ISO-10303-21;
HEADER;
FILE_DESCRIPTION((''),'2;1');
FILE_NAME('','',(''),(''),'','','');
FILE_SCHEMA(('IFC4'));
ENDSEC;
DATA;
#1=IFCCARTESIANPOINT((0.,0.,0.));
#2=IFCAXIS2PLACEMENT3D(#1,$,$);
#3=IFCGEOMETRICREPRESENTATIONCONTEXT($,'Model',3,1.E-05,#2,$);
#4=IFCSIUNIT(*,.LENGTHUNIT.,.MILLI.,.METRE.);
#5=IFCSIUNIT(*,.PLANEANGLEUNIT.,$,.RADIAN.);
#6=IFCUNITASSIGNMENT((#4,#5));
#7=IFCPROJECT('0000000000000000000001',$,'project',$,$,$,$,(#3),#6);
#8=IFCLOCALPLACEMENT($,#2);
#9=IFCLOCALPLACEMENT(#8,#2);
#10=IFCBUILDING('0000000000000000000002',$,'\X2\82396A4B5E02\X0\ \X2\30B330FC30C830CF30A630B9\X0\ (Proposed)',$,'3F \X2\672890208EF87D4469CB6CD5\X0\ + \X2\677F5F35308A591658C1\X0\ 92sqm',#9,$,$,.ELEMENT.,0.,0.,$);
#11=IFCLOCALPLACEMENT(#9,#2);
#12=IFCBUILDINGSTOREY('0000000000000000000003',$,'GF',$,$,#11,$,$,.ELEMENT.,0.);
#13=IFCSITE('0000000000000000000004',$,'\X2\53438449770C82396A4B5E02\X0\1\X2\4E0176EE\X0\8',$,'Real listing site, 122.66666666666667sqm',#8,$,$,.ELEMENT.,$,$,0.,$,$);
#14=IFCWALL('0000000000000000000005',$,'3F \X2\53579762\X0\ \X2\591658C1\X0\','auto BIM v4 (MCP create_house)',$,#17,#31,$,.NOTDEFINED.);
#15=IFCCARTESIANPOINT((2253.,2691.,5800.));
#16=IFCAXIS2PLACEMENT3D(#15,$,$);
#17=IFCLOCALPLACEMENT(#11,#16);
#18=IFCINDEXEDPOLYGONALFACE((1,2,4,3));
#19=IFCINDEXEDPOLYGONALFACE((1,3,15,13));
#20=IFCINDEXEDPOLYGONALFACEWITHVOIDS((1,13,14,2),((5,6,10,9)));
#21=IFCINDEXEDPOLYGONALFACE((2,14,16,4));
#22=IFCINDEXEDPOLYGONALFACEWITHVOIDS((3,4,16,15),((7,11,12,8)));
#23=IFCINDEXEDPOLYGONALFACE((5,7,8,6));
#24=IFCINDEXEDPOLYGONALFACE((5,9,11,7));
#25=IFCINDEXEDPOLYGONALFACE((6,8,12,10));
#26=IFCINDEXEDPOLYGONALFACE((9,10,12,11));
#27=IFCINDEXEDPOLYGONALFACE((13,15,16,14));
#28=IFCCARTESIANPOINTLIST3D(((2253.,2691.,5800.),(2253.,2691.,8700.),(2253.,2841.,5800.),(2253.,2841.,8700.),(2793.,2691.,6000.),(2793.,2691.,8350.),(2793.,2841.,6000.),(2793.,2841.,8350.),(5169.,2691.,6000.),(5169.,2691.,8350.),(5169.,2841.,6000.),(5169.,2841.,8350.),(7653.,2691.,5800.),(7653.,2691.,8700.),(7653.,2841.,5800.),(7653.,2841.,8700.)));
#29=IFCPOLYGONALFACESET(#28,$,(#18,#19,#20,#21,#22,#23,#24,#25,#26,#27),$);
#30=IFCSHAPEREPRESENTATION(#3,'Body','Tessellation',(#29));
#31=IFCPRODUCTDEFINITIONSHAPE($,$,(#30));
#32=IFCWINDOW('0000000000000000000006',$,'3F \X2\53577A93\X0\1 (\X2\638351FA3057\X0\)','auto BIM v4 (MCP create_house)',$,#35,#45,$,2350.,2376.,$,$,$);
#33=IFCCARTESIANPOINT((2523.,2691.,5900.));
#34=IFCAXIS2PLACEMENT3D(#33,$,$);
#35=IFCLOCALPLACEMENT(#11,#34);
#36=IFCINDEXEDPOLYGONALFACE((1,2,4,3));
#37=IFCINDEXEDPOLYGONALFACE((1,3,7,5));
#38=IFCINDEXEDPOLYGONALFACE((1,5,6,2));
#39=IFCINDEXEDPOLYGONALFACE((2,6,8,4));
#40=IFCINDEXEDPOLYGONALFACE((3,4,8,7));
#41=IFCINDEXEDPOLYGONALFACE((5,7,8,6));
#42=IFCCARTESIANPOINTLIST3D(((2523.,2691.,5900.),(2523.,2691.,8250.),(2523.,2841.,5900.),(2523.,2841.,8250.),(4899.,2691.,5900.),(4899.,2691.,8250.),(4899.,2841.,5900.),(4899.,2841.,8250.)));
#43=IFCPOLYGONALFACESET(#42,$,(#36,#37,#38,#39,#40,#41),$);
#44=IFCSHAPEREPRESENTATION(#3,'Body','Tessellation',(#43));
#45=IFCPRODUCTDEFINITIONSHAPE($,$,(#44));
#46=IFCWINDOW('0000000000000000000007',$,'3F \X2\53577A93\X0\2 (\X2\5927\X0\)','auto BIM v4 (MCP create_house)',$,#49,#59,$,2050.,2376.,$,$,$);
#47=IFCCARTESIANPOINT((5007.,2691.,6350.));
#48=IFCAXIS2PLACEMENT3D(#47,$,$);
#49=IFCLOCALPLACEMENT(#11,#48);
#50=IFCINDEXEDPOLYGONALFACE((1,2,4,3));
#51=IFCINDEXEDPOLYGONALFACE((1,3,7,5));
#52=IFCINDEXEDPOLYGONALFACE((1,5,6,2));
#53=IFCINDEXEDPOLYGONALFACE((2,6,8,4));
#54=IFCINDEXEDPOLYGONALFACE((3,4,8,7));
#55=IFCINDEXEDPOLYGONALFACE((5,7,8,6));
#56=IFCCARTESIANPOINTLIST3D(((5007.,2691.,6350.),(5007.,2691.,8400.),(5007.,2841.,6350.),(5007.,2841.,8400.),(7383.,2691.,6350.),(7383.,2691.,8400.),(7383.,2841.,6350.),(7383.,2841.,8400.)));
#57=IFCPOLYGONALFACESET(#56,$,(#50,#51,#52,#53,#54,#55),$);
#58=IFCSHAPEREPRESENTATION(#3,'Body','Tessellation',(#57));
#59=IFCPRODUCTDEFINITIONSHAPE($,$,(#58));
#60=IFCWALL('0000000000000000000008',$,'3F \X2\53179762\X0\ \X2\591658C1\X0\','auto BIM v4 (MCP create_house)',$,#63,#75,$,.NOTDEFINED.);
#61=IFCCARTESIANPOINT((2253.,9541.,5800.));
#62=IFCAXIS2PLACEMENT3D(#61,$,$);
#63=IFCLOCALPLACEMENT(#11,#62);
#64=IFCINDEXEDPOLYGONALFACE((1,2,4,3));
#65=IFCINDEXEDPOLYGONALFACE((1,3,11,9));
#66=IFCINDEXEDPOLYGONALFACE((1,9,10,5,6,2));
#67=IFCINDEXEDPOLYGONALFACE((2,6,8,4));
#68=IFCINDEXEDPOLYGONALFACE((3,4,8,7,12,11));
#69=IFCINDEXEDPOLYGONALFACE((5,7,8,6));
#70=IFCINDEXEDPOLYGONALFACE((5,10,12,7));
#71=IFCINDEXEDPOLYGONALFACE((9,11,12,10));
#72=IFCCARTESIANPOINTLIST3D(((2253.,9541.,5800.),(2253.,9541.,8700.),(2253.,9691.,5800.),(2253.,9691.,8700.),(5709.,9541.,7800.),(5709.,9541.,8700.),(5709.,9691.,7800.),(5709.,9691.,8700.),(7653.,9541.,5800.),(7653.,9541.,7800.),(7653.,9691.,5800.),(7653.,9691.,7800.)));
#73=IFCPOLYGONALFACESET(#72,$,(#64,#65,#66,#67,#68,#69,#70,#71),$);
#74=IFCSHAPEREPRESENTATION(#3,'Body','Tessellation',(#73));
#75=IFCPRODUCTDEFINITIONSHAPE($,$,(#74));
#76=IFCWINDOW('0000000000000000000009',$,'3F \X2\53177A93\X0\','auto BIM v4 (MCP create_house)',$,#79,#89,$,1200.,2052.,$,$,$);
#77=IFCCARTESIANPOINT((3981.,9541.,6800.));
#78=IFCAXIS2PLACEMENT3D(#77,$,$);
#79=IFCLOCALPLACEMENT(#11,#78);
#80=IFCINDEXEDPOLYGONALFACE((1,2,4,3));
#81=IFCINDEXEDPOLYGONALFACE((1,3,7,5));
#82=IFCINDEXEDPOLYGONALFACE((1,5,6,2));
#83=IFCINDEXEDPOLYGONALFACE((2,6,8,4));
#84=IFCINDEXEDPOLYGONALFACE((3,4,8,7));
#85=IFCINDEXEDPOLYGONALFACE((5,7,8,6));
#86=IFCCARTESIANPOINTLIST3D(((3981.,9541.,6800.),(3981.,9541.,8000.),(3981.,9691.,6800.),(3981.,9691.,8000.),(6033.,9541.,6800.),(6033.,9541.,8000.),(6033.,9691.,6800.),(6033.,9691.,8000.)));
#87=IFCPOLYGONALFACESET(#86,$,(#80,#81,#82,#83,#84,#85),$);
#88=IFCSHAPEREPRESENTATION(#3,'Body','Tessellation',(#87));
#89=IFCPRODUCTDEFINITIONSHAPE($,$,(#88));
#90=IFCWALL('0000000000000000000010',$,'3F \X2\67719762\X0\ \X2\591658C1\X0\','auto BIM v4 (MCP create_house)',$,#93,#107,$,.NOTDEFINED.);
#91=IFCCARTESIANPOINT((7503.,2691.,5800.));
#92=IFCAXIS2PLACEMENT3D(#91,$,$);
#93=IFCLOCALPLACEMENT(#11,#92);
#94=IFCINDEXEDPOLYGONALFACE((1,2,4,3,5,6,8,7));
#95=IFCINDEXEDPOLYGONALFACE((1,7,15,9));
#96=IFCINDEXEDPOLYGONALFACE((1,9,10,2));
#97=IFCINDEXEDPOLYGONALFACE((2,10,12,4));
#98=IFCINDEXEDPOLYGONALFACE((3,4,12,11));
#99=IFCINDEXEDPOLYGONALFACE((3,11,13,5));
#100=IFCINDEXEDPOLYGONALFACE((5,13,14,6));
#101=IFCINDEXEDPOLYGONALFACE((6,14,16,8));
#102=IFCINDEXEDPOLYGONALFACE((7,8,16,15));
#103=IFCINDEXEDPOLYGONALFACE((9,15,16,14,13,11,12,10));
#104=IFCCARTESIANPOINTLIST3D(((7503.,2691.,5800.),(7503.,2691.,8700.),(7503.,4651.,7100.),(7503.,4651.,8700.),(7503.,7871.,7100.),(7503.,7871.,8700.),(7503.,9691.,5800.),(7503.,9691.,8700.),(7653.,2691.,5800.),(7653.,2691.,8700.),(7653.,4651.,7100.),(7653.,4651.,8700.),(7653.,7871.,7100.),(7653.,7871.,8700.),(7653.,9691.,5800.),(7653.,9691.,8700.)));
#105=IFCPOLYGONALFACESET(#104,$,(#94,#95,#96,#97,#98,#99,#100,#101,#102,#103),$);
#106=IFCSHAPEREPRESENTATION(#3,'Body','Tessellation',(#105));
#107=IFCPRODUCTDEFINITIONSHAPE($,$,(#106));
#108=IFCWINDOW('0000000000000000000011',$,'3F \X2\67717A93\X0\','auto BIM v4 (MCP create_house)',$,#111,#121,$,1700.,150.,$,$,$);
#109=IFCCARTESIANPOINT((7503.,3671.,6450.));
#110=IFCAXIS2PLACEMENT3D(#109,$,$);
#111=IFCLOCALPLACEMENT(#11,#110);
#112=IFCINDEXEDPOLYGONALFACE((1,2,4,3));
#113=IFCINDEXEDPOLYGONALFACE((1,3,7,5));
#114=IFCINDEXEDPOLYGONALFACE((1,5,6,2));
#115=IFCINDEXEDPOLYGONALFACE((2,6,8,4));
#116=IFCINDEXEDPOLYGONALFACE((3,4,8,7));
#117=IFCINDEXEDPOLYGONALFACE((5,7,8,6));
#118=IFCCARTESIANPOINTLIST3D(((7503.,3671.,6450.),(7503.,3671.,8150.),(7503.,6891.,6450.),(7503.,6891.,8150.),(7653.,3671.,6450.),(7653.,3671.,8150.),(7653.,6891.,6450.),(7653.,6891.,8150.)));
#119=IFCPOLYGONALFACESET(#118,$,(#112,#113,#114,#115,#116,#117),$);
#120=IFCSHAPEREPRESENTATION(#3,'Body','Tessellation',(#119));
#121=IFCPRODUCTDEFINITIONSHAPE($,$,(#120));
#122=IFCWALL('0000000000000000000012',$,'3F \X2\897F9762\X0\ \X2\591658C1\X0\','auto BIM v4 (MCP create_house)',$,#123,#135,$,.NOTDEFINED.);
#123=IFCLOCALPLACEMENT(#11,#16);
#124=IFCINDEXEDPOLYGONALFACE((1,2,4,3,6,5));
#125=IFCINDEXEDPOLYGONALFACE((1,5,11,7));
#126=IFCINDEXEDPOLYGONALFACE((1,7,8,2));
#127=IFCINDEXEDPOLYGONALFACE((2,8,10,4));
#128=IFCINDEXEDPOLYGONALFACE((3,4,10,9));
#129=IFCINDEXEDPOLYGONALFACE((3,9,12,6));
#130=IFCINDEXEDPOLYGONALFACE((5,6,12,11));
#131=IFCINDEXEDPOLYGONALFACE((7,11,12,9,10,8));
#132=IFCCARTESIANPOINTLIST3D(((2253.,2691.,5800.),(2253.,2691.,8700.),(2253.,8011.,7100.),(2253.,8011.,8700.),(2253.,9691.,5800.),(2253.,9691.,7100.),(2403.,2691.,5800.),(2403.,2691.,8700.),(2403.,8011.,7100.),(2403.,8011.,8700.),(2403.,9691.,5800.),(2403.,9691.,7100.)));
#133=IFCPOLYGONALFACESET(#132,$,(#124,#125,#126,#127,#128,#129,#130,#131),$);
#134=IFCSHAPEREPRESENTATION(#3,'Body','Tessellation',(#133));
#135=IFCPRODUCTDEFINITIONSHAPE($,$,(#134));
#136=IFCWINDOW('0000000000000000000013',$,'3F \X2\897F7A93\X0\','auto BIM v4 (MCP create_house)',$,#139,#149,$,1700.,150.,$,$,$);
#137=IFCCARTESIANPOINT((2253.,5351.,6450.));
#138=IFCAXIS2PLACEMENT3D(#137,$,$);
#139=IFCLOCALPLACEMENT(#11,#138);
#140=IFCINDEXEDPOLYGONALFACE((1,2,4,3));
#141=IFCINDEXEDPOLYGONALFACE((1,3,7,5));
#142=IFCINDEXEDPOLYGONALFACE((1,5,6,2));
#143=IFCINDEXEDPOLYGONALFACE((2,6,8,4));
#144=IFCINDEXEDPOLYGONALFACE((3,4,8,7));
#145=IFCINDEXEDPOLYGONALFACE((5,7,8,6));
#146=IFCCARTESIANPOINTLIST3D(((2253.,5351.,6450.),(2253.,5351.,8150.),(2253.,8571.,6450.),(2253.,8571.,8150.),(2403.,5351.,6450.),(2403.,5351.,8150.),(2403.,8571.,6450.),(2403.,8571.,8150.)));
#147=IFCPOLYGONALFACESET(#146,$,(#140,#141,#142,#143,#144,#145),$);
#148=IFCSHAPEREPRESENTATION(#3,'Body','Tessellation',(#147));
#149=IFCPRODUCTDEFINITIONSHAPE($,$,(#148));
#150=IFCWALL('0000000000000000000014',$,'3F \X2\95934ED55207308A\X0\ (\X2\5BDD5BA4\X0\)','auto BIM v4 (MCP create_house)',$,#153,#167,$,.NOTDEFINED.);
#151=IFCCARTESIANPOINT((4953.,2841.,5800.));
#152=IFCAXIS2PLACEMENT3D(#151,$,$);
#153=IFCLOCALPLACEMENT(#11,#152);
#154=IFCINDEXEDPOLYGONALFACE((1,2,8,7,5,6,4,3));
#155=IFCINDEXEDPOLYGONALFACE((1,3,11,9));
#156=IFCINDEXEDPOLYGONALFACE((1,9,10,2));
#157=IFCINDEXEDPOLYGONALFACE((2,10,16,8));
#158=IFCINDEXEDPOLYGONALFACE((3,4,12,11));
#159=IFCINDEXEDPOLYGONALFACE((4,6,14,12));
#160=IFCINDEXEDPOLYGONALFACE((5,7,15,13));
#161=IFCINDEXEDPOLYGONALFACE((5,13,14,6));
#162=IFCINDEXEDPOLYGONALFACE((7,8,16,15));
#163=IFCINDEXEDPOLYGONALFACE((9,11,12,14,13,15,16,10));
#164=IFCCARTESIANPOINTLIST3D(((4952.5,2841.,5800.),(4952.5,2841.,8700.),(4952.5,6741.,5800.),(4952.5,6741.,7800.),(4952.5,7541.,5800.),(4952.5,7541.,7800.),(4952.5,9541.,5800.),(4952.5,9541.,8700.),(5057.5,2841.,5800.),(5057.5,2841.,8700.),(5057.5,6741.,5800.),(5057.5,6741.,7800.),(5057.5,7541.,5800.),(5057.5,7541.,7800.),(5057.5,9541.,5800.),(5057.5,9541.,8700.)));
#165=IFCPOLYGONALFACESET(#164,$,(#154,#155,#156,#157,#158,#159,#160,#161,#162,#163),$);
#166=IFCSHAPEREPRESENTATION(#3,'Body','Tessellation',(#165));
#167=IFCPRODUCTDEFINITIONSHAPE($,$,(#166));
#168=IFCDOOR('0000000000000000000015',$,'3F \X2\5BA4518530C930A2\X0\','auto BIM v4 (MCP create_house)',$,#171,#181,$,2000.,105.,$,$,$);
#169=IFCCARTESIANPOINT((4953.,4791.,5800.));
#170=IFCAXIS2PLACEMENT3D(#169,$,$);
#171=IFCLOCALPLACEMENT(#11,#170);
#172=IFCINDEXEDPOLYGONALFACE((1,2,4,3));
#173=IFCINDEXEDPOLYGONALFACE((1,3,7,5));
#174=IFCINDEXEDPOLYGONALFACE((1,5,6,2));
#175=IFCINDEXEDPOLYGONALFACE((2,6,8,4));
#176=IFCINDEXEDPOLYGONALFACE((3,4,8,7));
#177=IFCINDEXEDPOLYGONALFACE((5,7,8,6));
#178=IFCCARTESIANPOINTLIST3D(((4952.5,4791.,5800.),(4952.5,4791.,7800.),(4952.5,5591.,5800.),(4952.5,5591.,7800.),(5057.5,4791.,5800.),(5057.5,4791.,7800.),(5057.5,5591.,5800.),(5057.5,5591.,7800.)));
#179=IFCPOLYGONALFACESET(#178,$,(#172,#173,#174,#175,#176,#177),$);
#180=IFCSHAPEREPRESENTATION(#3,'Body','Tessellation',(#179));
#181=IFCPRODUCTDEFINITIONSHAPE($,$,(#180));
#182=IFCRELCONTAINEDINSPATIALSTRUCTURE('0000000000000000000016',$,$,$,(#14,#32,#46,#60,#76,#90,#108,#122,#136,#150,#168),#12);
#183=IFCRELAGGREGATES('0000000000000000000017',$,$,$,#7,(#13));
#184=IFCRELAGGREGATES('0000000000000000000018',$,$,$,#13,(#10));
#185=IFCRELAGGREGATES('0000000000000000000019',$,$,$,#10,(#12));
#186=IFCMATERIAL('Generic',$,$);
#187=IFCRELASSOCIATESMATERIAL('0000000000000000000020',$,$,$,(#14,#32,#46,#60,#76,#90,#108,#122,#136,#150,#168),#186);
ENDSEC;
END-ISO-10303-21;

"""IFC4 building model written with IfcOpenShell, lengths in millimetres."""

from ifc_helpers import new_model, si_unit, frame, frame_2d, origin, place, context, project, spatial, rectangle, extrude, material, element, fill, save


model = new_model("IFC4")

# Units and contexts
model_context = context("Model", 3, precision=1e-05, world=origin())
ifc_project = project(units=[si_unit("LENGTHUNIT", "METRE", prefix="MILLI"), si_unit("PLANEANGLEUNIT", "RADIAN")], contexts=[model_context])

# Site, building, storey
site_placement = place(None, origin())
site = spatial("IfcSite", under=ifc_project, at=site_placement, Name="千葉県船橋市1丁目8", ObjectType="Real listing site, 122.66666666666667sqm", CompositionType="ELEMENT", RefElevation=0.0)
building_placement = place(site_placement, origin())
building = spatial("IfcBuilding", under=site, at=building_placement, Name="船橋市 コートハウス (Proposed)", ObjectType="3F 木造軸組構法 + 板張り外壁 92sqm", CompositionType="ELEMENT", ElevationOfRefHeight=0.0, ElevationOfTerrain=0.0)
storey_placement = place(building_placement, origin())
storey = spatial("IfcBuildingStorey", under=building, at=storey_placement, Name="GF", CompositionType="ELEMENT", Elevation=0.0)

# Shared definitions
ifc_material = material(Name="Generic")

# Wall, openings, windows
wall_1_placement = place(storey_placement, frame((2253.0, 2691.0, 5800.0)))
wall_1 = element("IfcWall", 1, at=wall_1_placement, inside=storey, material=ifc_material, Name="3F 南面 外壁", Description="auto BIM v4 (MCP create_house)", PredefinedType="NOTDEFINED", context=model_context, shape_type="SweptSolid", body=[
    extrude(rectangle(XDim=5400.0, YDim=150.0, at=frame_2d((2700.0, 75.0))), frame((2253.0, 2691.0, 5800.0)), (0.0, 0.0, 1.0), 2900.0),
])
opening_1_placement = place(storey_placement, frame((2523.0, 2691.0, 5900.0)))
opening_1 = element("IfcOpeningElement", 2, at=opening_1_placement, cuts=wall_1, PredefinedType="NOTDEFINED", context=model_context, shape_type="SweptSolid", body=[
    extrude(rectangle(XDim=2376.0, YDim=150.0, at=frame_2d((1188.0, 75.0))), frame((2523.0, 2691.0, 5900.0)), (0.0, 0.0, 1.0), 2350.0),
])
opening_2_placement = place(storey_placement, frame((5007.0, 2691.0, 6350.0)))
opening_2 = element("IfcOpeningElement", 3, at=opening_2_placement, cuts=wall_1, PredefinedType="NOTDEFINED", context=model_context, shape_type="SweptSolid", body=[
    extrude(rectangle(XDim=2376.0, YDim=150.0, at=frame_2d((1188.0, 75.0))), frame((5007.0, 2691.0, 6350.0)), (0.0, 0.0, 1.0), 2050.0),
])
window_1_placement = place(storey_placement, frame((2523.0, 2691.0, 5900.0)))
window_1 = element("IfcWindow", 4, at=window_1_placement, inside=storey, material=ifc_material, Name="3F 南窓1 (掃出し)", Description="auto BIM v4 (MCP create_house)", OverallHeight=2350.0, OverallWidth=2376.0, context=model_context, shape_type="SweptSolid", body=[
    extrude(rectangle(XDim=2376.0, YDim=150.0, at=frame_2d((1188.0, 75.0))), frame((2523.0, 2691.0, 5900.0)), (0.0, 0.0, 1.0), 2350.0),
])
fill(opening_1, window_1)
window_2_placement = place(storey_placement, frame((5007.0, 2691.0, 6350.0)))
window_2 = element("IfcWindow", 5, at=window_2_placement, inside=storey, material=ifc_material, Name="3F 南窓2 (大)", Description="auto BIM v4 (MCP create_house)", OverallHeight=2050.0, OverallWidth=2376.0, context=model_context, shape_type="SweptSolid", body=[
    extrude(rectangle(XDim=2376.0, YDim=150.0, at=frame_2d((1188.0, 75.0))), frame((5007.0, 2691.0, 6350.0)), (0.0, 0.0, 1.0), 2050.0),
])
fill(opening_2, window_2)

# Walls, openings, windows
wall_2_placement = place(storey_placement, frame((2253.0, 9541.0, 5800.0)))
wall_2 = element("IfcWall", 6, at=wall_2_placement, inside=storey, material=ifc_material, Name="3F 北面 外壁", Description="auto BIM v4 (MCP create_house)", PredefinedType="NOTDEFINED", context=model_context, shape_type="SweptSolid", body=[
    extrude(rectangle(XDim=5400.0, YDim=150.0, at=frame_2d((2700.0, 75.0))), frame((2253.0, 9541.0, 5800.0)), (0.0, 0.0, 1.0), 2900.0),
])
opening_3_placement = place(storey_placement, frame((3981.0, 9541.0, 6800.0)))
opening_3 = element("IfcOpeningElement", 7, at=opening_3_placement, cuts=wall_2, PredefinedType="NOTDEFINED", context=model_context, shape_type="SweptSolid", body=[
    extrude(rectangle(XDim=2052.0, YDim=150.0, at=frame_2d((1026.0, 75.0))), frame((3981.0, 9541.0, 6800.0)), (0.0, 0.0, 1.0), 1200.0),
])
window_3_placement = place(storey_placement, frame((3981.0, 9541.0, 6800.0)))
window_3 = element("IfcWindow", 8, at=window_3_placement, inside=storey, material=ifc_material, Name="3F 北窓", Description="auto BIM v4 (MCP create_house)", OverallHeight=1200.0, OverallWidth=2052.0, context=model_context, shape_type="SweptSolid", body=[
    extrude(rectangle(XDim=2052.0, YDim=150.0, at=frame_2d((1026.0, 75.0))), frame((3981.0, 9541.0, 6800.0)), (0.0, 0.0, 1.0), 1200.0),
])
fill(opening_3, window_3)
wall_3_placement = place(storey_placement, frame((7503.0, 2691.0, 5800.0)))
wall_3 = element("IfcWall", 9, at=wall_3_placement, inside=storey, material=ifc_material, Name="3F 東面 外壁", Description="auto BIM v4 (MCP create_house)", PredefinedType="NOTDEFINED", context=model_context, shape_type="SweptSolid", body=[
    extrude(rectangle(XDim=150.0, YDim=7000.0, at=frame_2d((75.0, 3500.0))), frame((7503.0, 2691.0, 5800.0)), (0.0, 0.0, 1.0), 2900.0),
])
opening_4_placement = place(storey_placement, frame((7503.0, 3671.0, 6450.0)))
opening_4 = element("IfcOpeningElement", 10, at=opening_4_placement, cuts=wall_3, PredefinedType="NOTDEFINED", context=model_context, shape_type="SweptSolid", body=[
    extrude(rectangle(XDim=150.0, YDim=3220.0, at=frame_2d((75.0, 1610.0))), frame((7503.0, 3671.0, 6450.0)), (0.0, 0.0, 1.0), 1700.0),
])
window_4_placement = place(storey_placement, frame((7503.0, 3671.0, 6450.0)))
window_4 = element("IfcWindow", 11, at=window_4_placement, inside=storey, material=ifc_material, Name="3F 東窓", Description="auto BIM v4 (MCP create_house)", OverallHeight=1700.0, OverallWidth=150.0, context=model_context, shape_type="SweptSolid", body=[
    extrude(rectangle(XDim=150.0, YDim=3220.0, at=frame_2d((75.0, 1610.0))), frame((7503.0, 3671.0, 6450.0)), (0.0, 0.0, 1.0), 1700.0),
])
fill(opening_4, window_4)
wall_4_placement = place(storey_placement, frame((2253.0, 2691.0, 5800.0)))
wall_4 = element("IfcWall", 12, at=wall_4_placement, inside=storey, material=ifc_material, Name="3F 西面 外壁", Description="auto BIM v4 (MCP create_house)", PredefinedType="NOTDEFINED", context=model_context, shape_type="SweptSolid", body=[
    extrude(rectangle(XDim=150.0, YDim=7000.0, at=frame_2d((75.0, 3500.0))), frame((2253.0, 2691.0, 5800.0)), (0.0, 0.0, 1.0), 2900.0),
])
opening_5_placement = place(storey_placement, frame((2253.0, 5351.0, 6450.0)))
opening_5 = element("IfcOpeningElement", 13, at=opening_5_placement, cuts=wall_4, PredefinedType="NOTDEFINED", context=model_context, shape_type="SweptSolid", body=[
    extrude(rectangle(XDim=150.0, YDim=3220.0, at=frame_2d((75.0, 1610.0))), frame((2253.0, 5351.0, 6450.0)), (0.0, 0.0, 1.0), 1700.0),
])
window_5_placement = place(storey_placement, frame((2253.0, 5351.0, 6450.0)))
window_5 = element("IfcWindow", 14, at=window_5_placement, inside=storey, material=ifc_material, Name="3F 西窓", Description="auto BIM v4 (MCP create_house)", OverallHeight=1700.0, OverallWidth=150.0, context=model_context, shape_type="SweptSolid", body=[
    extrude(rectangle(XDim=150.0, YDim=3220.0, at=frame_2d((75.0, 1610.0))), frame((2253.0, 5351.0, 6450.0)), (0.0, 0.0, 1.0), 1700.0),
])
fill(opening_5, window_5)

# Wall, opening, door
wall_5_placement = place(storey_placement, frame((4953.0, 2841.0, 5800.0)))
wall_5 = element("IfcWall", 15, at=wall_5_placement, inside=storey, material=ifc_material, Name="3F 間仕切り (寝室)", Description="auto BIM v4 (MCP create_house)", PredefinedType="NOTDEFINED", context=model_context, shape_type="SweptSolid", body=[
    extrude(rectangle(XDim=105.0, YDim=6700.0, at=frame_2d((52.0, 3350.0))), frame((4953.0, 2841.0, 5800.0)), (0.0, 0.0, 1.0), 2900.0),
])
opening_6_placement = place(storey_placement, frame((4953.0, 4791.0, 5800.0)))
opening_6 = element("IfcOpeningElement", 16, at=opening_6_placement, cuts=wall_5, PredefinedType="NOTDEFINED", context=model_context, shape_type="SweptSolid", body=[
    extrude(rectangle(XDim=105.0, YDim=800.0, at=frame_2d((52.0, 400.0))), frame((4953.0, 4791.0, 5800.0)), (0.0, 0.0, 1.0), 2000.0),
])
door_1_placement = place(storey_placement, frame((4953.0, 4791.0, 5800.0)))
door_1 = element("IfcDoor", 17, at=door_1_placement, inside=storey, material=ifc_material, Name="3F 室内ドア", Description="auto BIM v4 (MCP create_house)", OverallHeight=2000.0, OverallWidth=105.0, context=model_context, shape_type="SweptSolid", body=[
    extrude(rectangle(XDim=105.0, YDim=800.0, at=frame_2d((52.0, 400.0))), frame((4953.0, 4791.0, 5800.0)), (0.0, 0.0, 1.0), 2000.0),
])
fill(opening_6, door_1)

save(model, "model.ifc")
